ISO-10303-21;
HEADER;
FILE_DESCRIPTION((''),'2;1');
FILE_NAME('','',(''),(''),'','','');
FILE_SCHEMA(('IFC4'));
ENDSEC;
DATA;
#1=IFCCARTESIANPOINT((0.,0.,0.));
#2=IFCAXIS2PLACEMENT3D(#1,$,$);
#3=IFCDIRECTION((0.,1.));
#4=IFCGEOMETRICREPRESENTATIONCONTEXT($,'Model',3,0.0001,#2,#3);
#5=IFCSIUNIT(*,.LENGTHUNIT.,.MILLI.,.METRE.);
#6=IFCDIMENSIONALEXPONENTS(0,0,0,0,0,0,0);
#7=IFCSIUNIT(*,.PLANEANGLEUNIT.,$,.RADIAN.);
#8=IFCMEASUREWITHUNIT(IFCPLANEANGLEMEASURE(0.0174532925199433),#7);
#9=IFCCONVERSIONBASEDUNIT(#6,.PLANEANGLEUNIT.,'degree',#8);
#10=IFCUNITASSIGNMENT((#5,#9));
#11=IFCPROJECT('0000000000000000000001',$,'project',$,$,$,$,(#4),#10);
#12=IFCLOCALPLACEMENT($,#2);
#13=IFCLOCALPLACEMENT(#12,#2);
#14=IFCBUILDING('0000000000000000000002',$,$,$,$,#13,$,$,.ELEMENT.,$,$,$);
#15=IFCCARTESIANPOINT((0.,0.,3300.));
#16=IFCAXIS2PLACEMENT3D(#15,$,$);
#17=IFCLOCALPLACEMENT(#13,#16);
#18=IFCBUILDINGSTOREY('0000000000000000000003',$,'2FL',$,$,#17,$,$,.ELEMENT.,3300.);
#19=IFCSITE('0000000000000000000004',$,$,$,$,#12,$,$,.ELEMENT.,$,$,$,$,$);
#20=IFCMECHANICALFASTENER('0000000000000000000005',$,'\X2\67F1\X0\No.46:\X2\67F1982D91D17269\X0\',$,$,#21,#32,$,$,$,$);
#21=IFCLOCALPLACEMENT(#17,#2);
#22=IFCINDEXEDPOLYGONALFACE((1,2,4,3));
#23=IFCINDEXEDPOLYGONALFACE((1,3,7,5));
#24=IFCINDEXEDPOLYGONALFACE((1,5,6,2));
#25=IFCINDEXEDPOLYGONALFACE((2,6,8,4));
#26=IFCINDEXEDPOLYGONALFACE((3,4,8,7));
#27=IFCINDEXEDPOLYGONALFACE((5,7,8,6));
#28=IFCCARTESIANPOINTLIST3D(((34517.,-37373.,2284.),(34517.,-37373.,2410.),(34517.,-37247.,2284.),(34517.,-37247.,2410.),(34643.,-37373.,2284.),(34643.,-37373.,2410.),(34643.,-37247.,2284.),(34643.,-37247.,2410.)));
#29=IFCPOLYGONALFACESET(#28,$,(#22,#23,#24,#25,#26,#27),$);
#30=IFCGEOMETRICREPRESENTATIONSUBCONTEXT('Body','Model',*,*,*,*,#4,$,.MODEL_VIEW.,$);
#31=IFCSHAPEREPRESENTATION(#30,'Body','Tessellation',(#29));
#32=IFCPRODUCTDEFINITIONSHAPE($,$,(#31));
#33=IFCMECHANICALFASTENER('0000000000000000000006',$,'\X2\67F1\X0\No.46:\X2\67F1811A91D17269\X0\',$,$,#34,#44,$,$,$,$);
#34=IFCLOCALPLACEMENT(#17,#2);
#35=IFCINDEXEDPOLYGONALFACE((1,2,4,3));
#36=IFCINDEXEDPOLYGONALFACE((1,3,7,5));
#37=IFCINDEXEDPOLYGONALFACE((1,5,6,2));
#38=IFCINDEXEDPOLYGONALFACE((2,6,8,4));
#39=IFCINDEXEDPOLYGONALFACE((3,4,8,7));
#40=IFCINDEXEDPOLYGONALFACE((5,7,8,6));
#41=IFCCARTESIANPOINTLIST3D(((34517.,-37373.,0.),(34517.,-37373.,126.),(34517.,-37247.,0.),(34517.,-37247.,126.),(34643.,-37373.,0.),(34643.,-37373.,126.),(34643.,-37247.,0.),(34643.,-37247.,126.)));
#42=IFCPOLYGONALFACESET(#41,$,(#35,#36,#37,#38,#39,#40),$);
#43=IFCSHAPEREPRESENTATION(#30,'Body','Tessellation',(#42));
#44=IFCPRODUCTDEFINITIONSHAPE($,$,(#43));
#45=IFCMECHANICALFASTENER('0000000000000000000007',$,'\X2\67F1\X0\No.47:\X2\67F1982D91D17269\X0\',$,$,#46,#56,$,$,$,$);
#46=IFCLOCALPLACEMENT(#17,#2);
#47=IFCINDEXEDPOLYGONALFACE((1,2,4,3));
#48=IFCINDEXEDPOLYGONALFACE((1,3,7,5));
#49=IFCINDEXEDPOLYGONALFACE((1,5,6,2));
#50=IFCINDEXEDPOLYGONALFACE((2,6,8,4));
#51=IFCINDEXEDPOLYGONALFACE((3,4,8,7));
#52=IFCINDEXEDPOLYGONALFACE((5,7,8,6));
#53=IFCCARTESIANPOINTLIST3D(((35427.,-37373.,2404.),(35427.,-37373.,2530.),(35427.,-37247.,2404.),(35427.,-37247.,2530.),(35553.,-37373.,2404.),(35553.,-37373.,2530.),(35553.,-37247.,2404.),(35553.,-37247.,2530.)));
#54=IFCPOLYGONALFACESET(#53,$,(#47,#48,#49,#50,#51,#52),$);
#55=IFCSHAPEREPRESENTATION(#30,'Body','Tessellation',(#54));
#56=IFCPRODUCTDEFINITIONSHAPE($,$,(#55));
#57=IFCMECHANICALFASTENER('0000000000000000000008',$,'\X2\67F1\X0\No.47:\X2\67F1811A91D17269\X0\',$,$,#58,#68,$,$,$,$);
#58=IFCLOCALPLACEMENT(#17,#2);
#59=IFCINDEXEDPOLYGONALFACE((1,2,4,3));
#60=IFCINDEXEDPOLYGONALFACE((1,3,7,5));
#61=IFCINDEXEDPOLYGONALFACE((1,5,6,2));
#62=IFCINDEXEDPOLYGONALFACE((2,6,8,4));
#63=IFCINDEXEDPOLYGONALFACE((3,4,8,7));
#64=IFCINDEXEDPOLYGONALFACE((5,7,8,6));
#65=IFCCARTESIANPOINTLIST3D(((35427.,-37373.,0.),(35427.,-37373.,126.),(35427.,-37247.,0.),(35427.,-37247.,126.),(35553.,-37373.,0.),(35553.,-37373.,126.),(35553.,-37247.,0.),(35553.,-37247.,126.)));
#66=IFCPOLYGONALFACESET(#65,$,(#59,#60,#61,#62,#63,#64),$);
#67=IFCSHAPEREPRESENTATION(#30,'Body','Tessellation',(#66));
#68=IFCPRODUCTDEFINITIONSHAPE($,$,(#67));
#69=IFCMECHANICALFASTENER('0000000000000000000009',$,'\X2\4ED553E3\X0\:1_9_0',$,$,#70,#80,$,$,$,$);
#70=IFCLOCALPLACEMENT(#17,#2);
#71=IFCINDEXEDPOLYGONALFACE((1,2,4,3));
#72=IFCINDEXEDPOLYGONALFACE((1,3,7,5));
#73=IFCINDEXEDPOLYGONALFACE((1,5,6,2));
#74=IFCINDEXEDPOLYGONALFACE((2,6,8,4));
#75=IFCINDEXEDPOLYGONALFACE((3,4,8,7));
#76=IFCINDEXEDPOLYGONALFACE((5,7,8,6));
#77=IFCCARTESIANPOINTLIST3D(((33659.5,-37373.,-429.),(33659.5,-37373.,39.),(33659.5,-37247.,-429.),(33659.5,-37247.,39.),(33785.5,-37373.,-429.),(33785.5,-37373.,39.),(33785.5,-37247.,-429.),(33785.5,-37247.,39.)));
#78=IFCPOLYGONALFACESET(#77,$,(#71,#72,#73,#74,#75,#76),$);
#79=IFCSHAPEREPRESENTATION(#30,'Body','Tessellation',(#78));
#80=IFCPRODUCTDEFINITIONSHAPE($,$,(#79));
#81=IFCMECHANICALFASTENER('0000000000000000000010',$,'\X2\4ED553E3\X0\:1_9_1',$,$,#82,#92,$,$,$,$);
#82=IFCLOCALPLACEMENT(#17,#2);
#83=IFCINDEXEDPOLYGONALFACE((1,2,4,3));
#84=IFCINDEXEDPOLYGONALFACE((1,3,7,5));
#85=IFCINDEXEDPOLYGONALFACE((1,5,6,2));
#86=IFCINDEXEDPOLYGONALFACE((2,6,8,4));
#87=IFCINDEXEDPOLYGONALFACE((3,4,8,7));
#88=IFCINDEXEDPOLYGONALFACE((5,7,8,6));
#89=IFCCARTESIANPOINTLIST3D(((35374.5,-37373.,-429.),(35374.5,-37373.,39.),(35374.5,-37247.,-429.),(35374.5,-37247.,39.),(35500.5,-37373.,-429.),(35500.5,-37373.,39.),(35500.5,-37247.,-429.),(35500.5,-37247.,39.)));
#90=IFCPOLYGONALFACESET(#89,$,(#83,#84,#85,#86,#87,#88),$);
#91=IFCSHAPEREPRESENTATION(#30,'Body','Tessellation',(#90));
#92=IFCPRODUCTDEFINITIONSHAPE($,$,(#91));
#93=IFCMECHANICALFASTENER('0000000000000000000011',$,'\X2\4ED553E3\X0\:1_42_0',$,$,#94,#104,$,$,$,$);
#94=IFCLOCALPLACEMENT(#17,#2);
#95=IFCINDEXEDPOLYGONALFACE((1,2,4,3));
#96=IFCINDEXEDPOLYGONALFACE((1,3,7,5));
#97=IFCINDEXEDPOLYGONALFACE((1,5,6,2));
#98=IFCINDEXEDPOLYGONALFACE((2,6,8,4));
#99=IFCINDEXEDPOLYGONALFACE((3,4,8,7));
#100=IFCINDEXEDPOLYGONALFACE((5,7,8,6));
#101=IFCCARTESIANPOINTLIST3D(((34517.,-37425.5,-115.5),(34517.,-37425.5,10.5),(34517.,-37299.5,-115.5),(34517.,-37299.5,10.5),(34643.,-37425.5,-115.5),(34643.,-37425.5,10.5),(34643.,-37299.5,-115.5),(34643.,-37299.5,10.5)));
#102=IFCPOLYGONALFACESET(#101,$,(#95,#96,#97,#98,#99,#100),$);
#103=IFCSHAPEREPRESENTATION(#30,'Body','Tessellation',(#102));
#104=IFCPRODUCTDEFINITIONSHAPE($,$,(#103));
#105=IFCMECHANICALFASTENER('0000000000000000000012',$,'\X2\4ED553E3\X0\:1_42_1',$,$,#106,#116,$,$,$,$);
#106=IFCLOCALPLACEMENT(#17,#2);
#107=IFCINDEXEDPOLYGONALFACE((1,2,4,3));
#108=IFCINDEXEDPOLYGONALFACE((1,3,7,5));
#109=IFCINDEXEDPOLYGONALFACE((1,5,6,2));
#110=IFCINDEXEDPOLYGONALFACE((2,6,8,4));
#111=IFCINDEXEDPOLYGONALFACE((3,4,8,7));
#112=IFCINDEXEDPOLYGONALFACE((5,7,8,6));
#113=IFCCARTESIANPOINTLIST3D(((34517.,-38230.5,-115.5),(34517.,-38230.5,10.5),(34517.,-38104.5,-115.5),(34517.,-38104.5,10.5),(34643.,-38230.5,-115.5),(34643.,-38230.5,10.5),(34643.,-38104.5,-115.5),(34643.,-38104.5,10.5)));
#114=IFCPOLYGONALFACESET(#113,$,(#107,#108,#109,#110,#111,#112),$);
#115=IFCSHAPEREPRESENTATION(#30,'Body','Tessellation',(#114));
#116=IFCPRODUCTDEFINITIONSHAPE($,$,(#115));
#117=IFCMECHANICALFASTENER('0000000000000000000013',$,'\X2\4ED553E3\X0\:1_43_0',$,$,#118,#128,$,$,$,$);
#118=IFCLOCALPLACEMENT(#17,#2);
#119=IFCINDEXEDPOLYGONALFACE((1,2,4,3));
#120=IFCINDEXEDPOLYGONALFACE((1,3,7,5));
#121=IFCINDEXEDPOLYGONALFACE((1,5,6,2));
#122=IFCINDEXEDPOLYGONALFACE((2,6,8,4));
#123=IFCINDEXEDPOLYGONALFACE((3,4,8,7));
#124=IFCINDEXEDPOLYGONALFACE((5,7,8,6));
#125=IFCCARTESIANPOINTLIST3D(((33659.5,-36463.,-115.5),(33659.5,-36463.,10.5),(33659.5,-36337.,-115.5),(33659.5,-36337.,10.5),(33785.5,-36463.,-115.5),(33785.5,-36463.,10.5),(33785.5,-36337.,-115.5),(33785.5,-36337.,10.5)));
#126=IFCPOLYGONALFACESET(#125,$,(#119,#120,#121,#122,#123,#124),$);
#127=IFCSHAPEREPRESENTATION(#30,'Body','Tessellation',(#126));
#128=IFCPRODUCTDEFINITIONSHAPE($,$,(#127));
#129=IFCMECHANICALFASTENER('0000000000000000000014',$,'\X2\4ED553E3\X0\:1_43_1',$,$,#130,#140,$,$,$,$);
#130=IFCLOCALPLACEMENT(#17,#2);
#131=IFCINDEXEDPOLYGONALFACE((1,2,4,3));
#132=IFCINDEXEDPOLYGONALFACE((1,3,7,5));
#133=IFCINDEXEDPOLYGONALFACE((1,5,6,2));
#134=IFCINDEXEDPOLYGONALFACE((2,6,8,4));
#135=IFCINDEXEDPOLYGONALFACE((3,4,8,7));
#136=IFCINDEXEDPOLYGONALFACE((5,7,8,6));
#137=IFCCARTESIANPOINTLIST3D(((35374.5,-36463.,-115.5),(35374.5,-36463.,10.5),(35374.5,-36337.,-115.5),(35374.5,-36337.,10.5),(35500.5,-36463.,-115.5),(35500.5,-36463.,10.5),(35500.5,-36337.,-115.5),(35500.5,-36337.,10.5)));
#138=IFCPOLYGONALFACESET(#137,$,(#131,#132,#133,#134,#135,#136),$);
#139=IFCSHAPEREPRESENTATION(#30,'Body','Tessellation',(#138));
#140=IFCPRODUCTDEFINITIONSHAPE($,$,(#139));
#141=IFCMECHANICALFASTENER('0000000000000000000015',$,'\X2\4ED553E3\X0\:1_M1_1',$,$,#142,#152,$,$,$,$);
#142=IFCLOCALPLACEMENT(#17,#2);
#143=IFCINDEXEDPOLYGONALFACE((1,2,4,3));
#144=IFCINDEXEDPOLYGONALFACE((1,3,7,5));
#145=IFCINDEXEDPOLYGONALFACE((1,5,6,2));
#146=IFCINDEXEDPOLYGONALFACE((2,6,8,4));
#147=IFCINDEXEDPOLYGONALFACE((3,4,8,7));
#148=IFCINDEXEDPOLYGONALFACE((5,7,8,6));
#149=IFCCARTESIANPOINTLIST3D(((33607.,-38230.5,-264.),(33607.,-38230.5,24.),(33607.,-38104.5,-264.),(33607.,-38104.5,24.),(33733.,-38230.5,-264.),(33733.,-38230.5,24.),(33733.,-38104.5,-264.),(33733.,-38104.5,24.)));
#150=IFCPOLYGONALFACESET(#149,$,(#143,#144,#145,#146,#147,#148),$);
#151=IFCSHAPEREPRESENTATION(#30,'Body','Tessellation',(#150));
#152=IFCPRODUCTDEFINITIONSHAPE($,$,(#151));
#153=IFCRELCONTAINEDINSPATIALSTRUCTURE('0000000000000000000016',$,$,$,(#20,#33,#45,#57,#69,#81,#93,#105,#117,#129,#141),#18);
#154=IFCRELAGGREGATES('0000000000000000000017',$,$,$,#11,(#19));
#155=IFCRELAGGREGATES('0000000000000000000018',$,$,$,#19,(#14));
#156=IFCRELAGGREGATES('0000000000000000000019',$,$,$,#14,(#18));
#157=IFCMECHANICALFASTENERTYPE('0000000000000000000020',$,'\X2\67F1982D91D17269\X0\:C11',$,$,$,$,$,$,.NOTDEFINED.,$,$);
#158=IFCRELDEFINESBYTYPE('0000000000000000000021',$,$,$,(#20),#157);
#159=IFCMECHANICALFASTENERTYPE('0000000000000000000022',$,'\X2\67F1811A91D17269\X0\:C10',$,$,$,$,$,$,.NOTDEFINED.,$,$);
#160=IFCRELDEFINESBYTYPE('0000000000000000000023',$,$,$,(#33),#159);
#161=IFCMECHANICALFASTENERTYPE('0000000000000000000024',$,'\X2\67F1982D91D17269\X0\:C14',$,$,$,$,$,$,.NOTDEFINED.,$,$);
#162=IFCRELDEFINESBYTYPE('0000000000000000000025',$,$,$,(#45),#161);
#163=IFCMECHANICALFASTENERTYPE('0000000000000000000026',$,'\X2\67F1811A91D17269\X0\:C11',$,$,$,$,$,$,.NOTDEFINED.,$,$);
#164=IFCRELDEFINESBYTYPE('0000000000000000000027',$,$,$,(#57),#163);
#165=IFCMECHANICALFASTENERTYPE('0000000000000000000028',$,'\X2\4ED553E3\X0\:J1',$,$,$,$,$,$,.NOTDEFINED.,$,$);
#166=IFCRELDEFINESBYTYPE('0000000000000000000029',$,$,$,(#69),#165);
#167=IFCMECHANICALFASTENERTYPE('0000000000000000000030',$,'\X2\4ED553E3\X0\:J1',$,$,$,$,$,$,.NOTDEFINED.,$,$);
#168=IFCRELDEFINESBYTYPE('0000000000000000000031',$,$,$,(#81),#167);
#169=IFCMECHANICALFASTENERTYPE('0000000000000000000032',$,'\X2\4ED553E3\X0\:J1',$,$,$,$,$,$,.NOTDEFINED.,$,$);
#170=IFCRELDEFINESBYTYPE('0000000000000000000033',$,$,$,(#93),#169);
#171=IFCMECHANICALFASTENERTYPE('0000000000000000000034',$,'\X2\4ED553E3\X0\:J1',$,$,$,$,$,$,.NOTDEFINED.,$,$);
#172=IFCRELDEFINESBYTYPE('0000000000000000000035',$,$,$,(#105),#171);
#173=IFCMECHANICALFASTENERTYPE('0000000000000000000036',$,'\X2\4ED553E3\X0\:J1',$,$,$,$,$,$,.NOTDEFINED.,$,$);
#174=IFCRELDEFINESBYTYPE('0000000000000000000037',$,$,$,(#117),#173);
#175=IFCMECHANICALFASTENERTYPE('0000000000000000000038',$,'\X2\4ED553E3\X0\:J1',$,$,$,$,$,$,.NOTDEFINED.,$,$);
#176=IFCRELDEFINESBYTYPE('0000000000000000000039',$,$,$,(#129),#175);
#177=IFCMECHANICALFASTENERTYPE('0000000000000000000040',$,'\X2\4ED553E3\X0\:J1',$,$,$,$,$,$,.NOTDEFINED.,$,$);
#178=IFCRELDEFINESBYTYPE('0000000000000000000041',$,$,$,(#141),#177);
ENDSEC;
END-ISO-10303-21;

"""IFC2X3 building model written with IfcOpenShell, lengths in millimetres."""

from ifc_helpers import new_model, entity, si_unit, converted_unit, direction, frame, origin, origin_with_axes, origin_2d, place, context, subcontext, project, spatial, rectangle, extrude, type_object, element, save


model = new_model("IFC2X3")

# Units and contexts
model_context = context("Model", 3, precision=0.0001, world=origin(), true_north=direction((0.0, 1.0)))
body_context = subcontext(model_context, "Body", "Model", "MODEL_VIEW")
ifc_project = project(units=[si_unit("LENGTHUNIT", "METRE", prefix="MILLI"), converted_unit("PLANEANGLEUNIT", "degree", entity("IfcPlaneAngleMeasure", 0.0174532925199433), si_unit("PLANEANGLEUNIT", "RADIAN"), dimensions=[0, 0, 0, 0, 0, 0, 0])], contexts=[model_context])

# Site, building, storey
site_placement = place(None, origin())
site = spatial("IfcSite", under=ifc_project, at=site_placement, CompositionType="ELEMENT")
building_placement = place(site_placement, origin())
building = spatial("IfcBuilding", under=site, at=building_placement, CompositionType="ELEMENT")
storey_placement = place(building_placement, frame((0.0, 0.0, 3300.0)))
storey = spatial("IfcBuildingStorey", under=building, at=storey_placement, Name="2FL", CompositionType="ELEMENT", Elevation=3300.0)

# Mechanical fasteners
mechanical_fastener_type_1 = type_object("IfcMechanicalFastenerType", Name="柱頭金物:C11")
mechanical_fastener_1_placement = place(storey_placement, frame((34580.0, -37310.0, 2284.0)))
element("IfcMechanicalFastener", 1, at=mechanical_fastener_1_placement, inside=storey, type_object=mechanical_fastener_type_1, Name="柱No.46:柱頭金物", context=body_context, shape_type="SweptSolid", body=[
    extrude(rectangle(XDim=126.0, YDim=126.0, at=origin_2d()), origin_with_axes(), (0.0, 0.0, 1.0), 126.0),
])
mechanical_fastener_type_2 = type_object("IfcMechanicalFastenerType", Name="柱脚金物:C10")
mechanical_fastener_2_placement = place(storey_placement, frame((34580.0, -37310.0, 0.0)))
element("IfcMechanicalFastener", 2, at=mechanical_fastener_2_placement, inside=storey, type_object=mechanical_fastener_type_2, Name="柱No.46:柱脚金物", context=body_context, shape_type="SweptSolid", body=[
    extrude(rectangle(XDim=126.0, YDim=126.0, at=origin_2d()), origin_with_axes(), (0.0, 0.0, 1.0), 126.0),
])
mechanical_fastener_type_3 = type_object("IfcMechanicalFastenerType", Name="柱頭金物:C14")
mechanical_fastener_3_placement = place(storey_placement, frame((35490.0, -37310.0, 2404.0)))
element("IfcMechanicalFastener", 3, at=mechanical_fastener_3_placement, inside=storey, type_object=mechanical_fastener_type_3, Name="柱No.47:柱頭金物", context=body_context, shape_type="SweptSolid", body=[
    extrude(rectangle(XDim=126.0, YDim=126.0, at=origin_2d()), origin_with_axes(), (0.0, 0.0, 1.0), 126.0),
])
mechanical_fastener_type_4 = type_object("IfcMechanicalFastenerType", Name="柱脚金物:C11")
mechanical_fastener_4_placement = place(storey_placement, frame((35490.0, -37310.0, 0.0)))
element("IfcMechanicalFastener", 4, at=mechanical_fastener_4_placement, inside=storey, type_object=mechanical_fastener_type_4, Name="柱No.47:柱脚金物", context=body_context, shape_type="SweptSolid", body=[
    extrude(rectangle(XDim=126.0, YDim=126.0, at=origin_2d()), origin_with_axes(), (0.0, 0.0, 1.0), 126.0),
])
mechanical_fastener_type_5 = type_object("IfcMechanicalFastenerType", Name="仕口:J1")
mechanical_fastener_5_placement = place(storey_placement, frame((33722.5, -37310.0, -429.0)))
element("IfcMechanicalFastener", 5, at=mechanical_fastener_5_placement, inside=storey, type_object=mechanical_fastener_type_5, Name="仕口:1_9_0", context=body_context, shape_type="SweptSolid", body=[
    extrude(rectangle(XDim=126.0, YDim=126.0, at=origin_2d()), origin_with_axes(), (0.0, 0.0, 1.0), 468.0),
])
mechanical_fastener_type_6 = type_object("IfcMechanicalFastenerType", Name="仕口:J1")
mechanical_fastener_6_placement = place(storey_placement, frame((35437.5, -37310.0, -429.0)))
element("IfcMechanicalFastener", 6, at=mechanical_fastener_6_placement, inside=storey, type_object=mechanical_fastener_type_6, Name="仕口:1_9_1", context=body_context, shape_type="SweptSolid", body=[
    extrude(rectangle(XDim=126.0, YDim=126.0, at=origin_2d()), origin_with_axes(), (0.0, 0.0, 1.0), 468.0),
])
mechanical_fastener_type_7 = type_object("IfcMechanicalFastenerType", Name="仕口:J1")
mechanical_fastener_7_placement = place(storey_placement, frame((34580.0, -37362.5, -115.5)))
element("IfcMechanicalFastener", 7, at=mechanical_fastener_7_placement, inside=storey, type_object=mechanical_fastener_type_7, Name="仕口:1_42_0", context=body_context, shape_type="SweptSolid", body=[
    extrude(rectangle(XDim=126.0, YDim=126.0, at=origin_2d()), origin_with_axes(), (0.0, 0.0, 1.0), 126.0),
])
mechanical_fastener_type_8 = type_object("IfcMechanicalFastenerType", Name="仕口:J1")
mechanical_fastener_8_placement = place(storey_placement, frame((34580.0, -38167.5, -115.5)))
element("IfcMechanicalFastener", 8, at=mechanical_fastener_8_placement, inside=storey, type_object=mechanical_fastener_type_8, Name="仕口:1_42_1", context=body_context, shape_type="SweptSolid", body=[
    extrude(rectangle(XDim=126.0, YDim=126.0, at=origin_2d()), origin_with_axes(), (0.0, 0.0, 1.0), 126.0),
])
mechanical_fastener_type_9 = type_object("IfcMechanicalFastenerType", Name="仕口:J1")
mechanical_fastener_9_placement = place(storey_placement, frame((33722.5, -36400.0, -115.5)))
element("IfcMechanicalFastener", 9, at=mechanical_fastener_9_placement, inside=storey, type_object=mechanical_fastener_type_9, Name="仕口:1_43_0", context=body_context, shape_type="SweptSolid", body=[
    extrude(rectangle(XDim=126.0, YDim=126.0, at=origin_2d()), origin_with_axes(), (0.0, 0.0, 1.0), 126.0),
])
mechanical_fastener_type_10 = type_object("IfcMechanicalFastenerType", Name="仕口:J1")
mechanical_fastener_10_placement = place(storey_placement, frame((35437.5, -36400.0, -115.5)))
element("IfcMechanicalFastener", 10, at=mechanical_fastener_10_placement, inside=storey, type_object=mechanical_fastener_type_10, Name="仕口:1_43_1", context=body_context, shape_type="SweptSolid", body=[
    extrude(rectangle(XDim=126.0, YDim=126.0, at=origin_2d()), origin_with_axes(), (0.0, 0.0, 1.0), 126.0),
])
mechanical_fastener_type_11 = type_object("IfcMechanicalFastenerType", Name="仕口:J1")
mechanical_fastener_11_placement = place(storey_placement, frame((33670.0, -38167.5, -264.0)))
element("IfcMechanicalFastener", 11, at=mechanical_fastener_11_placement, inside=storey, type_object=mechanical_fastener_type_11, Name="仕口:1_M1_1", context=body_context, shape_type="SweptSolid", body=[
    extrude(rectangle(XDim=126.0, YDim=126.0, at=origin_2d()), origin_with_axes(), (0.0, 0.0, 1.0), 288.0),
])

save(model, "model.ifc")
